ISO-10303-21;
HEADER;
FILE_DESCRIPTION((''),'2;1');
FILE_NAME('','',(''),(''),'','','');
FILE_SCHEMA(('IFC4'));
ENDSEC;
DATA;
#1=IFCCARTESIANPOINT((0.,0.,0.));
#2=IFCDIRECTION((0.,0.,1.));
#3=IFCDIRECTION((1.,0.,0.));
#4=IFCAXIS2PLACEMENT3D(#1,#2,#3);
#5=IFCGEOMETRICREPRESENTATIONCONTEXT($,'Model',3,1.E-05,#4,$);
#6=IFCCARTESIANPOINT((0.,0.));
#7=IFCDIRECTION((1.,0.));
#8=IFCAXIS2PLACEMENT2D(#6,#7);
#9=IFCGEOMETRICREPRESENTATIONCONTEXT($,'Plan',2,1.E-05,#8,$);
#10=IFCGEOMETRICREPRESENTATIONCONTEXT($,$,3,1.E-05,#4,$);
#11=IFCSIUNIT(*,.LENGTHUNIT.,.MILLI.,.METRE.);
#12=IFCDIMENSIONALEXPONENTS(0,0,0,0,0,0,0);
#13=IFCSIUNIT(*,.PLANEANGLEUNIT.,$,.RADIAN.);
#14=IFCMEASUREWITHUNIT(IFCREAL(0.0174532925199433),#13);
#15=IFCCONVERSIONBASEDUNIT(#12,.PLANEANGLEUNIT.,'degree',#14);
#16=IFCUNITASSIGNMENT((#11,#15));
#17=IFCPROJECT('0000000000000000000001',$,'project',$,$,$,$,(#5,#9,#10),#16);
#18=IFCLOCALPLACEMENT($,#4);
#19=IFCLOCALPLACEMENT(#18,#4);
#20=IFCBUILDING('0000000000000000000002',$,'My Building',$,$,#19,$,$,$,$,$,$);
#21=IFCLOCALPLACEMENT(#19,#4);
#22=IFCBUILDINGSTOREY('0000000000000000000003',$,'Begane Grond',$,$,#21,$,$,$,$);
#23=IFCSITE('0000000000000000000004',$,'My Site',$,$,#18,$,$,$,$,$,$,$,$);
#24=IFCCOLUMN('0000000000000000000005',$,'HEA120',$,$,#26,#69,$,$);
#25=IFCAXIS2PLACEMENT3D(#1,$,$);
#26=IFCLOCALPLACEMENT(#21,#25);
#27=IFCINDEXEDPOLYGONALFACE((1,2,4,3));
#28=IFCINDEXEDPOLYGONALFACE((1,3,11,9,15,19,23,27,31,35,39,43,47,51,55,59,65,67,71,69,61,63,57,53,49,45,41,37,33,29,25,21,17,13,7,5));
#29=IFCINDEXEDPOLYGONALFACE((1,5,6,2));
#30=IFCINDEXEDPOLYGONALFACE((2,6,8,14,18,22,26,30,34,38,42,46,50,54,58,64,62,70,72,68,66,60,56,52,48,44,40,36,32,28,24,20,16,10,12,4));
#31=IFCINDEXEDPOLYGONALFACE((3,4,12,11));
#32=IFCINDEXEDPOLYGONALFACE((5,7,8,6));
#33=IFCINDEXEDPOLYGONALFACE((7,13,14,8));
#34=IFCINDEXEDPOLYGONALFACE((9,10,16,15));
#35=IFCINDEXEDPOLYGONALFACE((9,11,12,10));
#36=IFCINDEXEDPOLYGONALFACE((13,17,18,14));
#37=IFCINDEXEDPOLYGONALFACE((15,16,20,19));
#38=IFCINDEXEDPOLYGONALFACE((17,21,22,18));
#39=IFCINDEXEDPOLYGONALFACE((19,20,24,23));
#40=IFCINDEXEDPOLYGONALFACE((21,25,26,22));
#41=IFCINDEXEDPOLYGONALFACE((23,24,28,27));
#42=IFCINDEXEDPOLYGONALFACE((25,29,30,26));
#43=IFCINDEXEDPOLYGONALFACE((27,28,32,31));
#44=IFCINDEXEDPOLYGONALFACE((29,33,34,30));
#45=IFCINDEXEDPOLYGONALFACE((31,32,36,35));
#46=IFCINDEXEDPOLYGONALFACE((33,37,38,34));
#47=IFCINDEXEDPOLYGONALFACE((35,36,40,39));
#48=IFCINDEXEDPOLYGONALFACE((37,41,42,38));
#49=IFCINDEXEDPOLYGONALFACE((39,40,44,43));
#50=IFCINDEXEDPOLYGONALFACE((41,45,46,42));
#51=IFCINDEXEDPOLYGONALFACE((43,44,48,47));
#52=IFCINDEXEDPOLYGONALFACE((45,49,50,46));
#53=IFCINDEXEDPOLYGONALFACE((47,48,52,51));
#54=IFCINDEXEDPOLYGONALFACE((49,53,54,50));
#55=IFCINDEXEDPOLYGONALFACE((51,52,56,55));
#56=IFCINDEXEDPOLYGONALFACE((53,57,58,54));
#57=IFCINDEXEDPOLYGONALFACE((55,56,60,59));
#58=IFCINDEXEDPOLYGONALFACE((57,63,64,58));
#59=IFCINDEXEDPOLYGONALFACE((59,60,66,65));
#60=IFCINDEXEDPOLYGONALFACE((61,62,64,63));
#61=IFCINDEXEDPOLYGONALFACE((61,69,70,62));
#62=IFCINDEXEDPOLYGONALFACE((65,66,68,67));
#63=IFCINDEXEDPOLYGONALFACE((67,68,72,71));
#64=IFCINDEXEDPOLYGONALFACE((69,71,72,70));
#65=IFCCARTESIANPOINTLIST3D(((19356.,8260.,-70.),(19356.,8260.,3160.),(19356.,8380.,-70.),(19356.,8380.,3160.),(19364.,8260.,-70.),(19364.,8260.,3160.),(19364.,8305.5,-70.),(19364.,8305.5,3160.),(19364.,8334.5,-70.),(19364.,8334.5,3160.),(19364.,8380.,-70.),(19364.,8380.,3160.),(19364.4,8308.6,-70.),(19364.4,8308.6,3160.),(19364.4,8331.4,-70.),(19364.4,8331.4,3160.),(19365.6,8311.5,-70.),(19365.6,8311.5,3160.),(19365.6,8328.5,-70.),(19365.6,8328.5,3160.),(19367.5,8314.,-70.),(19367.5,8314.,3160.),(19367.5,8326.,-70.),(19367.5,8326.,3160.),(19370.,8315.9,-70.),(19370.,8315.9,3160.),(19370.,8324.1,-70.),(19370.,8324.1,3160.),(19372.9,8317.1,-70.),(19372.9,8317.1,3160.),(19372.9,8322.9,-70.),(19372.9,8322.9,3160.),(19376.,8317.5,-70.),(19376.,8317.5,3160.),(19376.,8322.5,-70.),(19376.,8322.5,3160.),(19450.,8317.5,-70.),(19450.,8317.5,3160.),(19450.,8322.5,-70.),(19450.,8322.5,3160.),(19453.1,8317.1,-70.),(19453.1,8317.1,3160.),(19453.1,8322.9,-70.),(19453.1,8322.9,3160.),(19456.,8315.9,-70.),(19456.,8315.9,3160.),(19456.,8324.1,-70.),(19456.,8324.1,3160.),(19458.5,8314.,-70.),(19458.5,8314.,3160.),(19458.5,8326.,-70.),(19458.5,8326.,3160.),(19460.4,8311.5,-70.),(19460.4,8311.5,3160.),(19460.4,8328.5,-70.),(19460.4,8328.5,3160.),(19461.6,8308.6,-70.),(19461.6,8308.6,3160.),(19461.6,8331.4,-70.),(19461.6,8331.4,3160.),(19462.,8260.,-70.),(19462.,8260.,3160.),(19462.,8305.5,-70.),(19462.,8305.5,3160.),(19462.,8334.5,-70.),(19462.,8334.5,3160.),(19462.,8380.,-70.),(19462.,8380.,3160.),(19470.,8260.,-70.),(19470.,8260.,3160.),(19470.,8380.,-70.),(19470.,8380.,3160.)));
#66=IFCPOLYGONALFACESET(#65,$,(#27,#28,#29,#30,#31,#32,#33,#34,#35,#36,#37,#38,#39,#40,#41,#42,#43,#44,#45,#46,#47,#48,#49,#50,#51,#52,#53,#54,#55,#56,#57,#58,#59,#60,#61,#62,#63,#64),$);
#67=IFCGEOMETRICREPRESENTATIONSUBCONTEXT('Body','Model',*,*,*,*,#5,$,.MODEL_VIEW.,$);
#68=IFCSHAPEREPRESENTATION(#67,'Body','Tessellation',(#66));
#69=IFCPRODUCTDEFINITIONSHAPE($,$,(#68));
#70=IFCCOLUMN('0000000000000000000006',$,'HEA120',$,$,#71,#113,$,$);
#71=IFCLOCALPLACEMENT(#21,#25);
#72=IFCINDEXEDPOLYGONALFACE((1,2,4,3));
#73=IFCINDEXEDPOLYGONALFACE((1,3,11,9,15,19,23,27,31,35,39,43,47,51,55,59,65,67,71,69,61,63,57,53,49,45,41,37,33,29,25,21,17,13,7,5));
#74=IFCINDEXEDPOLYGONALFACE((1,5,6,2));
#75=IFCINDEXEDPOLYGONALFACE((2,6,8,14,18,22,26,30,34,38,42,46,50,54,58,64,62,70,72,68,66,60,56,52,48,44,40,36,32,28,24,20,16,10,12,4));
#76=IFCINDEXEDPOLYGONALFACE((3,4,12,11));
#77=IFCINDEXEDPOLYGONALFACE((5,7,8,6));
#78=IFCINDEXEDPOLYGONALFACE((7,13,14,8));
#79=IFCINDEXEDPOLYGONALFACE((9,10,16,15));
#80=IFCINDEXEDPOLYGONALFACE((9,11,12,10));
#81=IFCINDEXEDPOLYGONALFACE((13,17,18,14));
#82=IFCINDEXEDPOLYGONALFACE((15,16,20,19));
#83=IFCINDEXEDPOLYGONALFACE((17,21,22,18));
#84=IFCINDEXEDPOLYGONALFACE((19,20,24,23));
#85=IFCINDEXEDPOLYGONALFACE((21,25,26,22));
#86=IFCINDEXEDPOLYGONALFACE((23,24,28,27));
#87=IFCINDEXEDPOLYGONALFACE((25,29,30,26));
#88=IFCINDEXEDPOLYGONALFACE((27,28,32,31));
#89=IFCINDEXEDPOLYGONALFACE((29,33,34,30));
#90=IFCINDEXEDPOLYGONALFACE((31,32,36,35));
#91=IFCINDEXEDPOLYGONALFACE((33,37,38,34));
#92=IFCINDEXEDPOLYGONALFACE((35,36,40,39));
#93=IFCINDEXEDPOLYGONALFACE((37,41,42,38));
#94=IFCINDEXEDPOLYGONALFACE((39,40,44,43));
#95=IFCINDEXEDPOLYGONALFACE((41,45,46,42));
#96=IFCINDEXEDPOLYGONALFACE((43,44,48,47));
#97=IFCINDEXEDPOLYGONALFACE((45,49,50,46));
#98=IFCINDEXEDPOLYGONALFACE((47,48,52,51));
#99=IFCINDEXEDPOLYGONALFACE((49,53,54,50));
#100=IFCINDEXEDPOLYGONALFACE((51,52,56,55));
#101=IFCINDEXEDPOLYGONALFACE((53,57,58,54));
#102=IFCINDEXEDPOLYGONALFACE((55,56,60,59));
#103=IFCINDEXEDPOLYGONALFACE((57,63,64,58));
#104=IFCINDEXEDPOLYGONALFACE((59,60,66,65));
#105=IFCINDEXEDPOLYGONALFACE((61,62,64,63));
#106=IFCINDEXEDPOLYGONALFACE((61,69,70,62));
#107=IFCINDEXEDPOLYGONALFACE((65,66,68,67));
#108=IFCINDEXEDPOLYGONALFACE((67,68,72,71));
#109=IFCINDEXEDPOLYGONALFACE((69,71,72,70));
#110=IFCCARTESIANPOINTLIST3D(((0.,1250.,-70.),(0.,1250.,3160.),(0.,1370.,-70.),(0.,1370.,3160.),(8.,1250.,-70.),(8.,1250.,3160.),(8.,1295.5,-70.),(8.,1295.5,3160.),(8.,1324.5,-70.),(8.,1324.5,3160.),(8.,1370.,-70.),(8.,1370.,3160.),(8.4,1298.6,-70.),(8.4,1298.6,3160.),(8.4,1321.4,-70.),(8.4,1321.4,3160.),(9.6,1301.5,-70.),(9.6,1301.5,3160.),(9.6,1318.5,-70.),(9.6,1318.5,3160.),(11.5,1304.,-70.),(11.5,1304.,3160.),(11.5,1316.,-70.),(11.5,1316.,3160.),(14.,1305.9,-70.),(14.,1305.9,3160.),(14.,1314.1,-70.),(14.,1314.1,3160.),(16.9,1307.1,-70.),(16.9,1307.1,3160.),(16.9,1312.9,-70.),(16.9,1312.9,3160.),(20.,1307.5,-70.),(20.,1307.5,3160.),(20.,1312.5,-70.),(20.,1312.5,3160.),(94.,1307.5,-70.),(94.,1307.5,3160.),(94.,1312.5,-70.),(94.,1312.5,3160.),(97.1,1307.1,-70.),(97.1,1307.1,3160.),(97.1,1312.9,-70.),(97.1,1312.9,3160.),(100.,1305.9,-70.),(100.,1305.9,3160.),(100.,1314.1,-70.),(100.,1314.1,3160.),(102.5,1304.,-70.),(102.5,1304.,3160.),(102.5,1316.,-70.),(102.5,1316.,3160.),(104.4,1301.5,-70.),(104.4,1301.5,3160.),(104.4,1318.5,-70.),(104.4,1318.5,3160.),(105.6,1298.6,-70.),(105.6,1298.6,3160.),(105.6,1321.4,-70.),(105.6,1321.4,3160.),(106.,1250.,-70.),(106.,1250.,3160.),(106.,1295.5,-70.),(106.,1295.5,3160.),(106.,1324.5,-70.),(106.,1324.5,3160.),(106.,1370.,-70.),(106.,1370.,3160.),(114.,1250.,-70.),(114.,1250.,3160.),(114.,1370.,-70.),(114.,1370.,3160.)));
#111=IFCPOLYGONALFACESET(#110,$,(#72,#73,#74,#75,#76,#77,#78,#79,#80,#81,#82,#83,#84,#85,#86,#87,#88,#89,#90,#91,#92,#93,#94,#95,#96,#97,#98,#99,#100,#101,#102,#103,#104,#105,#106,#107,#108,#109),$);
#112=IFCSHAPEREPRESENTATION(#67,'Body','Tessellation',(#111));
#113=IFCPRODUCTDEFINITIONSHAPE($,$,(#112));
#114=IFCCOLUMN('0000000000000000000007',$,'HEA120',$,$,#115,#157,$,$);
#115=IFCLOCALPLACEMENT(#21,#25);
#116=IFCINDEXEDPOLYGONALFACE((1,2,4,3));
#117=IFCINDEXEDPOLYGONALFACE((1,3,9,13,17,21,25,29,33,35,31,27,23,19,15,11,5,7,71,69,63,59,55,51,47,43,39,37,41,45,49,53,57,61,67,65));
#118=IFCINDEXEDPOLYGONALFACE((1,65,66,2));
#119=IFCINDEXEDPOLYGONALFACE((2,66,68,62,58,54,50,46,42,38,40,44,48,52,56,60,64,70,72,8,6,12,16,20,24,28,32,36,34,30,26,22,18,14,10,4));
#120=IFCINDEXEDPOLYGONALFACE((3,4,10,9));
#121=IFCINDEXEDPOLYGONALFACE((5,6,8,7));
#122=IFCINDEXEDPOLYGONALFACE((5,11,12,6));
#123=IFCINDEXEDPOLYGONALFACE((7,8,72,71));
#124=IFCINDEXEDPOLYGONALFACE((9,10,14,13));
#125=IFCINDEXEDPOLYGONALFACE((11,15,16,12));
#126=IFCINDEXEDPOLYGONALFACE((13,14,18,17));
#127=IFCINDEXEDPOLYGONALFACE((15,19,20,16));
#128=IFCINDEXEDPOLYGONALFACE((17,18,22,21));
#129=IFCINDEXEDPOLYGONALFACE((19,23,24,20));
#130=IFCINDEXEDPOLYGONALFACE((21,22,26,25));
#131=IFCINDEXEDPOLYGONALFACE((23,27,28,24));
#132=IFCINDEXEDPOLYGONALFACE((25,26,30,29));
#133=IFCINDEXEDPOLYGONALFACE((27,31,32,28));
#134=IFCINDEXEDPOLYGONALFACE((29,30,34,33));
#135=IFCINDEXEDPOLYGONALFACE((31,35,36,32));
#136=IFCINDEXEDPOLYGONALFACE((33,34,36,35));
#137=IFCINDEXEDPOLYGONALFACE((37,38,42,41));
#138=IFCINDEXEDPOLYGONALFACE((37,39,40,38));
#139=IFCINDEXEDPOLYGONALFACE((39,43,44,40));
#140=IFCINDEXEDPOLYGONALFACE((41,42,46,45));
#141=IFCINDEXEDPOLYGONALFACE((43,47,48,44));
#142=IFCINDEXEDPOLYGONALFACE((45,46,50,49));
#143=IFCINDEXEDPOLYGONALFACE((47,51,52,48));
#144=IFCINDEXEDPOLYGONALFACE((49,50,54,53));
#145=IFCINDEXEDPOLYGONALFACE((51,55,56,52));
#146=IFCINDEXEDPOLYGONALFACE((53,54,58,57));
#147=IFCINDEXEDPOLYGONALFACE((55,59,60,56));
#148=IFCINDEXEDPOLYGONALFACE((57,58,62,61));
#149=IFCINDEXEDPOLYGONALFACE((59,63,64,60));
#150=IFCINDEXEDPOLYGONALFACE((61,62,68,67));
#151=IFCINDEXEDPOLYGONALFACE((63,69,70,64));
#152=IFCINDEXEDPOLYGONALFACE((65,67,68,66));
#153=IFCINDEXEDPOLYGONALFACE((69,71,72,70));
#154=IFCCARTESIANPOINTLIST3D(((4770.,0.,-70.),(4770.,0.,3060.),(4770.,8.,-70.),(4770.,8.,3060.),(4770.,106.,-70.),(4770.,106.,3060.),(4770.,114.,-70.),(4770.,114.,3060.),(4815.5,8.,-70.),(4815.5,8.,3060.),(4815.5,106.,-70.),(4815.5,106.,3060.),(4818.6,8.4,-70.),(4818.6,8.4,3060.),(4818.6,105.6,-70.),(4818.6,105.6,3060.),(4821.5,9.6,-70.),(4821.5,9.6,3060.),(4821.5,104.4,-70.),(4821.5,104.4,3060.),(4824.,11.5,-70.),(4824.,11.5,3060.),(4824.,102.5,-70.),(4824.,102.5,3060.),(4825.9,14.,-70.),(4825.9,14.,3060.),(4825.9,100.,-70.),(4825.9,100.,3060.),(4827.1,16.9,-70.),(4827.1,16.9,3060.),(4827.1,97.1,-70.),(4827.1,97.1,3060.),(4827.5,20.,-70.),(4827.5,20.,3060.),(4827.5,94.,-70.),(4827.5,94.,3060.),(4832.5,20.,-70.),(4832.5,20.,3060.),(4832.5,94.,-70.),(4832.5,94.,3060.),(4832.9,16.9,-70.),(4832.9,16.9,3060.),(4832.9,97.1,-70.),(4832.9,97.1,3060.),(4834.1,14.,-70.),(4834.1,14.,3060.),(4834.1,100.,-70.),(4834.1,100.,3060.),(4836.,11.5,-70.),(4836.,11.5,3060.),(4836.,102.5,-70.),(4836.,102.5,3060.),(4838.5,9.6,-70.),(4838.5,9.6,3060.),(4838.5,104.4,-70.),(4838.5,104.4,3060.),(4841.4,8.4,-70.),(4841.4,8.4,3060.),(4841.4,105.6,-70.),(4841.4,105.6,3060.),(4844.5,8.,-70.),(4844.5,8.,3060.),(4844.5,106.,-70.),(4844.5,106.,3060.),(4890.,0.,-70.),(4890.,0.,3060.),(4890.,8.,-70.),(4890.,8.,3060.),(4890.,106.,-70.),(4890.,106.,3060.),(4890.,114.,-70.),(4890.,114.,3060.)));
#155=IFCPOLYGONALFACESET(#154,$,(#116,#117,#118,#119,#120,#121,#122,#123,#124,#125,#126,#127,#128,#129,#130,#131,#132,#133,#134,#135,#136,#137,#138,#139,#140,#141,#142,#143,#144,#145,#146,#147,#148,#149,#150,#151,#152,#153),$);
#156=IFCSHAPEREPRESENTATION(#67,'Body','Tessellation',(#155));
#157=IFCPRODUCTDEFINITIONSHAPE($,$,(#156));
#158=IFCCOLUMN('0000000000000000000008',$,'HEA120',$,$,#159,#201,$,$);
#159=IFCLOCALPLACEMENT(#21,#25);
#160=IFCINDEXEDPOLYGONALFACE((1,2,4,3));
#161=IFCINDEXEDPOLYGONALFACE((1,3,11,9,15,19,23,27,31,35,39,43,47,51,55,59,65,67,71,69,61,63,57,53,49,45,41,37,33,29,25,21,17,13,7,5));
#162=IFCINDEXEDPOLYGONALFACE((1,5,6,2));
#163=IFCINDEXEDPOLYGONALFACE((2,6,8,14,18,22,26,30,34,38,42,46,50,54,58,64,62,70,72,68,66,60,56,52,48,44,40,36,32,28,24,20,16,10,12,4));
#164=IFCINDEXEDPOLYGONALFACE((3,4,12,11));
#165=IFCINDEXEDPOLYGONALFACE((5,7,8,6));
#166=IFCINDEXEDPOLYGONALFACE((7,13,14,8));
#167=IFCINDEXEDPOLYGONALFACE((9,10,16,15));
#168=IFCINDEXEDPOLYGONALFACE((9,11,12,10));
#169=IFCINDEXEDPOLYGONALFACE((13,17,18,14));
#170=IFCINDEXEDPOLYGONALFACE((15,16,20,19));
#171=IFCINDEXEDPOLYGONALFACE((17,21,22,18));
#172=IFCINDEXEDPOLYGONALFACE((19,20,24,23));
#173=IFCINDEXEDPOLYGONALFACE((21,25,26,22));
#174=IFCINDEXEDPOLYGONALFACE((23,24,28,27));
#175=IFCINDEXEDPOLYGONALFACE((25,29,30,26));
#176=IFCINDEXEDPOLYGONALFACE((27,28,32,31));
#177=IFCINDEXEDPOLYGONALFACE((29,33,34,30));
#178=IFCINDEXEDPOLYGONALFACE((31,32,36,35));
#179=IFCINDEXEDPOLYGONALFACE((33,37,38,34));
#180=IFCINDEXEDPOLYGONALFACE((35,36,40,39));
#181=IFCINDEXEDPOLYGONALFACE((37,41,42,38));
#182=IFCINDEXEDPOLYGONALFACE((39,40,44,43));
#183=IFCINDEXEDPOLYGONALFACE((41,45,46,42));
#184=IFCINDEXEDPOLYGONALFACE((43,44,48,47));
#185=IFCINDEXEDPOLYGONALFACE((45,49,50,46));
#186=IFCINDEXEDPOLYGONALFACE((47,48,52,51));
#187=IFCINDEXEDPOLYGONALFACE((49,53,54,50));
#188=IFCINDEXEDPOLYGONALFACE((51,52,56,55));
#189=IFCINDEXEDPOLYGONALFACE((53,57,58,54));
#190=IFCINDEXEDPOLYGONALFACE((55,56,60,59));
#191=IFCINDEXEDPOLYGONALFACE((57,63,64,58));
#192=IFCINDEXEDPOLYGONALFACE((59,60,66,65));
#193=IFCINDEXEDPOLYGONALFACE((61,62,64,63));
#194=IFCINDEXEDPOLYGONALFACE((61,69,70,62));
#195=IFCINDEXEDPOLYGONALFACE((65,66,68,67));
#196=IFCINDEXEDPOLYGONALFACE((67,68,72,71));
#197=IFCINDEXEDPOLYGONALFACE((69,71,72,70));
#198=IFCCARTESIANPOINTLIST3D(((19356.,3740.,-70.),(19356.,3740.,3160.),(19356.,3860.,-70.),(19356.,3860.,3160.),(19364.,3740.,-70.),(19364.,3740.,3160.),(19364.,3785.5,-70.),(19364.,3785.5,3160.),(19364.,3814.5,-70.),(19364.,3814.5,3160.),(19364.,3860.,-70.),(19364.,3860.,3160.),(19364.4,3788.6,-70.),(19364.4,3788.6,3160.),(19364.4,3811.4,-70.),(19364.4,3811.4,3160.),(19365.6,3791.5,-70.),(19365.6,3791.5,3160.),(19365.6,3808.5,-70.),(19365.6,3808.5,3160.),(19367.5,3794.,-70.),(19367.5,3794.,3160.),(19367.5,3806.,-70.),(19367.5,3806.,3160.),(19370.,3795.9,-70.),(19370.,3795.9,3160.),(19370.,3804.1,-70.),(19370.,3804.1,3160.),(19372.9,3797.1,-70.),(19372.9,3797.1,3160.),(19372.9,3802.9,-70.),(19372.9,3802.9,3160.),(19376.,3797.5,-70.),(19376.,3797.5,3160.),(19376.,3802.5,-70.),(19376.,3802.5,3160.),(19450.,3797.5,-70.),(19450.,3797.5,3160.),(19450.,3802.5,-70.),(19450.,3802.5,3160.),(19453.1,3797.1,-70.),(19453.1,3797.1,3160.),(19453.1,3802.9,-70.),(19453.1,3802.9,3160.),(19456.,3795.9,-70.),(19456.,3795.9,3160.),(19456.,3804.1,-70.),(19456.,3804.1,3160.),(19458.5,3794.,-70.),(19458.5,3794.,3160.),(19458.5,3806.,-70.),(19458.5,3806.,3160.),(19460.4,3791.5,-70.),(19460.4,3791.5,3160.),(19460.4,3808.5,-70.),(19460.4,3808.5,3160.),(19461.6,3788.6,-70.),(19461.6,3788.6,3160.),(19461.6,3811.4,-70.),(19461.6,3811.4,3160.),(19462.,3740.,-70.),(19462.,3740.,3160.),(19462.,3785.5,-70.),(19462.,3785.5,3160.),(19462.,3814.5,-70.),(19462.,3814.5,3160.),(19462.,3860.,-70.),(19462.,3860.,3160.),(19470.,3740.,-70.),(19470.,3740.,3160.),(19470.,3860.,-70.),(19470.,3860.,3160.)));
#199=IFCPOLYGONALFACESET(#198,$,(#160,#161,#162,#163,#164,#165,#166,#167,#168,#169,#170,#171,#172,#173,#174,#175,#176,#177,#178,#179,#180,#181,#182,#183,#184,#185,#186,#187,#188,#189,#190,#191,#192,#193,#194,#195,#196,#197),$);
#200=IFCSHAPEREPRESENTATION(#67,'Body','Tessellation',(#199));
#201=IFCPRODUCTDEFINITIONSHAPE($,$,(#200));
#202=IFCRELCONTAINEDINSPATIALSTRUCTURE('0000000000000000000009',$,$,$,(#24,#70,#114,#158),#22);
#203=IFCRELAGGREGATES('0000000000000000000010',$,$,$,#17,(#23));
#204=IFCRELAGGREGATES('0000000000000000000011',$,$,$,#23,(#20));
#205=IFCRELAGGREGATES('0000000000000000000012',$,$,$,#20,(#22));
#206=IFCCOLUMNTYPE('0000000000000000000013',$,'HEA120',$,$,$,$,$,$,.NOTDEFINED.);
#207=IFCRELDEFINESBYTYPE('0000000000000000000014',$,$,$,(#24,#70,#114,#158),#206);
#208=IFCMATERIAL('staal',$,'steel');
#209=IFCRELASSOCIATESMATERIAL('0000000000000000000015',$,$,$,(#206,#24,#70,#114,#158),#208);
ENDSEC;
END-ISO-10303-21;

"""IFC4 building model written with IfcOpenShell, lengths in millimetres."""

from ifc_helpers import new_model, entity, si_unit, converted_unit, frame, origin_with_axes, origin_2d_with_axis, place, context, subcontext, project, spatial, i_section, extrude, material, material_profile, profile_set, profile_usage, type_object, element, save


model = new_model("IFC4")

# Units and contexts
model_context = context("Model", 3, precision=1e-05, world=origin_with_axes())
plan_context = context("Plan", 2, precision=1e-05, world=origin_2d_with_axis())
context_of_model = context(None, 3, precision=1e-05, world=origin_with_axes())
body_context = subcontext(model_context, "Body", "Model", "MODEL_VIEW")
ifc_project = project(units=[si_unit("LENGTHUNIT", "METRE", prefix="MILLI"), converted_unit("PLANEANGLEUNIT", "degree", entity("IfcReal", 0.0174532925199433), si_unit("PLANEANGLEUNIT", "RADIAN"), dimensions=[0, 0, 0, 0, 0, 0, 0])], contexts=[model_context, plan_context, context_of_model])

# Site, building, storey
site_placement = place(None, origin_with_axes())
site = spatial("IfcSite", under=ifc_project, at=site_placement, Name="My Site")
building_placement = place(site_placement, origin_with_axes())
building = spatial("IfcBuilding", under=site, at=building_placement, Name="My Building")
storey_placement = place(building_placement, origin_with_axes())
storey = spatial("IfcBuildingStorey", under=building, at=storey_placement, Name="Begane Grond")

# Columns
ifc_material = material(Name="staal", Category="steel")
ifc_material_profile_1 = material_profile(ifc_material, i_section(OverallWidth=120.0, OverallDepth=114.0, WebThickness=5.0, FlangeThickness=8.0, FilletRadius=12.0))
ifc_profile_set_1 = profile_set([ifc_material_profile_1], Name="HEA120")
column_type_1 = type_object("IfcColumnType", Name="HEA120", PredefinedType="NOTDEFINED", material=ifc_profile_set_1)
ifc_profile_usage_1 = profile_usage(ifc_profile_set_1)
column_1_placement = place(storey_placement, frame((19413.0, 8320.0, -70.0), z_axis=(0.0, 0.0, 1.0), x_axis=(0.0, 1.0, 0.0)))
element("IfcColumn", 1, at=column_1_placement, inside=storey, type_object=column_type_1, material=ifc_profile_usage_1, Name="HEA120", context=body_context, shape_type="SweptSolid", body=[
    extrude(i_section(OverallWidth=120.0, OverallDepth=114.0, WebThickness=5.0, FlangeThickness=8.0, FilletRadius=12.0), origin_with_axes(), (0.0, 0.0, 1.0), 3230.0),
])
ifc_profile_usage_2 = profile_usage(ifc_profile_set_1)
column_2_placement = place(storey_placement, frame((57.0, 1310.0, -70.0), z_axis=(0.0, 0.0, 1.0), x_axis=(0.0, 1.0, 0.0)))
element("IfcColumn", 2, at=column_2_placement, inside=storey, type_object=column_type_1, material=ifc_profile_usage_2, Name="HEA120", context=body_context, shape_type="SweptSolid", body=[
    extrude(i_section(OverallWidth=120.0, OverallDepth=114.0, WebThickness=5.0, FlangeThickness=8.0, FilletRadius=12.0), origin_with_axes(), (0.0, 0.0, 1.0), 3230.0),
])
ifc_profile_usage_3 = profile_usage(ifc_profile_set_1)
column_3_placement = place(storey_placement, frame((4830.0, 57.0, -70.0), z_axis=(0.0, 0.0, 1.0), x_axis=(-1.0, 0.0, 0.0)))
element("IfcColumn", 3, at=column_3_placement, inside=storey, type_object=column_type_1, material=ifc_profile_usage_3, Name="HEA120", context=body_context, shape_type="SweptSolid", body=[
    extrude(i_section(OverallWidth=120.0, OverallDepth=114.0, WebThickness=5.0, FlangeThickness=8.0, FilletRadius=12.0), origin_with_axes(), (0.0, 0.0, 1.0), 3130.0),
])
ifc_profile_usage_4 = profile_usage(ifc_profile_set_1)
column_4_placement = place(storey_placement, frame((19413.0, 3800.0, -70.0), z_axis=(0.0, 0.0, 1.0), x_axis=(0.0, 1.0, 0.0)))
element("IfcColumn", 4, at=column_4_placement, inside=storey, type_object=column_type_1, material=ifc_profile_usage_4, Name="HEA120", context=body_context, shape_type="SweptSolid", body=[
    extrude(i_section(OverallWidth=120.0, OverallDepth=114.0, WebThickness=5.0, FlangeThickness=8.0, FilletRadius=12.0), origin_with_axes(), (0.0, 0.0, 1.0), 3230.0),
])

save(model, "model.ifc")
